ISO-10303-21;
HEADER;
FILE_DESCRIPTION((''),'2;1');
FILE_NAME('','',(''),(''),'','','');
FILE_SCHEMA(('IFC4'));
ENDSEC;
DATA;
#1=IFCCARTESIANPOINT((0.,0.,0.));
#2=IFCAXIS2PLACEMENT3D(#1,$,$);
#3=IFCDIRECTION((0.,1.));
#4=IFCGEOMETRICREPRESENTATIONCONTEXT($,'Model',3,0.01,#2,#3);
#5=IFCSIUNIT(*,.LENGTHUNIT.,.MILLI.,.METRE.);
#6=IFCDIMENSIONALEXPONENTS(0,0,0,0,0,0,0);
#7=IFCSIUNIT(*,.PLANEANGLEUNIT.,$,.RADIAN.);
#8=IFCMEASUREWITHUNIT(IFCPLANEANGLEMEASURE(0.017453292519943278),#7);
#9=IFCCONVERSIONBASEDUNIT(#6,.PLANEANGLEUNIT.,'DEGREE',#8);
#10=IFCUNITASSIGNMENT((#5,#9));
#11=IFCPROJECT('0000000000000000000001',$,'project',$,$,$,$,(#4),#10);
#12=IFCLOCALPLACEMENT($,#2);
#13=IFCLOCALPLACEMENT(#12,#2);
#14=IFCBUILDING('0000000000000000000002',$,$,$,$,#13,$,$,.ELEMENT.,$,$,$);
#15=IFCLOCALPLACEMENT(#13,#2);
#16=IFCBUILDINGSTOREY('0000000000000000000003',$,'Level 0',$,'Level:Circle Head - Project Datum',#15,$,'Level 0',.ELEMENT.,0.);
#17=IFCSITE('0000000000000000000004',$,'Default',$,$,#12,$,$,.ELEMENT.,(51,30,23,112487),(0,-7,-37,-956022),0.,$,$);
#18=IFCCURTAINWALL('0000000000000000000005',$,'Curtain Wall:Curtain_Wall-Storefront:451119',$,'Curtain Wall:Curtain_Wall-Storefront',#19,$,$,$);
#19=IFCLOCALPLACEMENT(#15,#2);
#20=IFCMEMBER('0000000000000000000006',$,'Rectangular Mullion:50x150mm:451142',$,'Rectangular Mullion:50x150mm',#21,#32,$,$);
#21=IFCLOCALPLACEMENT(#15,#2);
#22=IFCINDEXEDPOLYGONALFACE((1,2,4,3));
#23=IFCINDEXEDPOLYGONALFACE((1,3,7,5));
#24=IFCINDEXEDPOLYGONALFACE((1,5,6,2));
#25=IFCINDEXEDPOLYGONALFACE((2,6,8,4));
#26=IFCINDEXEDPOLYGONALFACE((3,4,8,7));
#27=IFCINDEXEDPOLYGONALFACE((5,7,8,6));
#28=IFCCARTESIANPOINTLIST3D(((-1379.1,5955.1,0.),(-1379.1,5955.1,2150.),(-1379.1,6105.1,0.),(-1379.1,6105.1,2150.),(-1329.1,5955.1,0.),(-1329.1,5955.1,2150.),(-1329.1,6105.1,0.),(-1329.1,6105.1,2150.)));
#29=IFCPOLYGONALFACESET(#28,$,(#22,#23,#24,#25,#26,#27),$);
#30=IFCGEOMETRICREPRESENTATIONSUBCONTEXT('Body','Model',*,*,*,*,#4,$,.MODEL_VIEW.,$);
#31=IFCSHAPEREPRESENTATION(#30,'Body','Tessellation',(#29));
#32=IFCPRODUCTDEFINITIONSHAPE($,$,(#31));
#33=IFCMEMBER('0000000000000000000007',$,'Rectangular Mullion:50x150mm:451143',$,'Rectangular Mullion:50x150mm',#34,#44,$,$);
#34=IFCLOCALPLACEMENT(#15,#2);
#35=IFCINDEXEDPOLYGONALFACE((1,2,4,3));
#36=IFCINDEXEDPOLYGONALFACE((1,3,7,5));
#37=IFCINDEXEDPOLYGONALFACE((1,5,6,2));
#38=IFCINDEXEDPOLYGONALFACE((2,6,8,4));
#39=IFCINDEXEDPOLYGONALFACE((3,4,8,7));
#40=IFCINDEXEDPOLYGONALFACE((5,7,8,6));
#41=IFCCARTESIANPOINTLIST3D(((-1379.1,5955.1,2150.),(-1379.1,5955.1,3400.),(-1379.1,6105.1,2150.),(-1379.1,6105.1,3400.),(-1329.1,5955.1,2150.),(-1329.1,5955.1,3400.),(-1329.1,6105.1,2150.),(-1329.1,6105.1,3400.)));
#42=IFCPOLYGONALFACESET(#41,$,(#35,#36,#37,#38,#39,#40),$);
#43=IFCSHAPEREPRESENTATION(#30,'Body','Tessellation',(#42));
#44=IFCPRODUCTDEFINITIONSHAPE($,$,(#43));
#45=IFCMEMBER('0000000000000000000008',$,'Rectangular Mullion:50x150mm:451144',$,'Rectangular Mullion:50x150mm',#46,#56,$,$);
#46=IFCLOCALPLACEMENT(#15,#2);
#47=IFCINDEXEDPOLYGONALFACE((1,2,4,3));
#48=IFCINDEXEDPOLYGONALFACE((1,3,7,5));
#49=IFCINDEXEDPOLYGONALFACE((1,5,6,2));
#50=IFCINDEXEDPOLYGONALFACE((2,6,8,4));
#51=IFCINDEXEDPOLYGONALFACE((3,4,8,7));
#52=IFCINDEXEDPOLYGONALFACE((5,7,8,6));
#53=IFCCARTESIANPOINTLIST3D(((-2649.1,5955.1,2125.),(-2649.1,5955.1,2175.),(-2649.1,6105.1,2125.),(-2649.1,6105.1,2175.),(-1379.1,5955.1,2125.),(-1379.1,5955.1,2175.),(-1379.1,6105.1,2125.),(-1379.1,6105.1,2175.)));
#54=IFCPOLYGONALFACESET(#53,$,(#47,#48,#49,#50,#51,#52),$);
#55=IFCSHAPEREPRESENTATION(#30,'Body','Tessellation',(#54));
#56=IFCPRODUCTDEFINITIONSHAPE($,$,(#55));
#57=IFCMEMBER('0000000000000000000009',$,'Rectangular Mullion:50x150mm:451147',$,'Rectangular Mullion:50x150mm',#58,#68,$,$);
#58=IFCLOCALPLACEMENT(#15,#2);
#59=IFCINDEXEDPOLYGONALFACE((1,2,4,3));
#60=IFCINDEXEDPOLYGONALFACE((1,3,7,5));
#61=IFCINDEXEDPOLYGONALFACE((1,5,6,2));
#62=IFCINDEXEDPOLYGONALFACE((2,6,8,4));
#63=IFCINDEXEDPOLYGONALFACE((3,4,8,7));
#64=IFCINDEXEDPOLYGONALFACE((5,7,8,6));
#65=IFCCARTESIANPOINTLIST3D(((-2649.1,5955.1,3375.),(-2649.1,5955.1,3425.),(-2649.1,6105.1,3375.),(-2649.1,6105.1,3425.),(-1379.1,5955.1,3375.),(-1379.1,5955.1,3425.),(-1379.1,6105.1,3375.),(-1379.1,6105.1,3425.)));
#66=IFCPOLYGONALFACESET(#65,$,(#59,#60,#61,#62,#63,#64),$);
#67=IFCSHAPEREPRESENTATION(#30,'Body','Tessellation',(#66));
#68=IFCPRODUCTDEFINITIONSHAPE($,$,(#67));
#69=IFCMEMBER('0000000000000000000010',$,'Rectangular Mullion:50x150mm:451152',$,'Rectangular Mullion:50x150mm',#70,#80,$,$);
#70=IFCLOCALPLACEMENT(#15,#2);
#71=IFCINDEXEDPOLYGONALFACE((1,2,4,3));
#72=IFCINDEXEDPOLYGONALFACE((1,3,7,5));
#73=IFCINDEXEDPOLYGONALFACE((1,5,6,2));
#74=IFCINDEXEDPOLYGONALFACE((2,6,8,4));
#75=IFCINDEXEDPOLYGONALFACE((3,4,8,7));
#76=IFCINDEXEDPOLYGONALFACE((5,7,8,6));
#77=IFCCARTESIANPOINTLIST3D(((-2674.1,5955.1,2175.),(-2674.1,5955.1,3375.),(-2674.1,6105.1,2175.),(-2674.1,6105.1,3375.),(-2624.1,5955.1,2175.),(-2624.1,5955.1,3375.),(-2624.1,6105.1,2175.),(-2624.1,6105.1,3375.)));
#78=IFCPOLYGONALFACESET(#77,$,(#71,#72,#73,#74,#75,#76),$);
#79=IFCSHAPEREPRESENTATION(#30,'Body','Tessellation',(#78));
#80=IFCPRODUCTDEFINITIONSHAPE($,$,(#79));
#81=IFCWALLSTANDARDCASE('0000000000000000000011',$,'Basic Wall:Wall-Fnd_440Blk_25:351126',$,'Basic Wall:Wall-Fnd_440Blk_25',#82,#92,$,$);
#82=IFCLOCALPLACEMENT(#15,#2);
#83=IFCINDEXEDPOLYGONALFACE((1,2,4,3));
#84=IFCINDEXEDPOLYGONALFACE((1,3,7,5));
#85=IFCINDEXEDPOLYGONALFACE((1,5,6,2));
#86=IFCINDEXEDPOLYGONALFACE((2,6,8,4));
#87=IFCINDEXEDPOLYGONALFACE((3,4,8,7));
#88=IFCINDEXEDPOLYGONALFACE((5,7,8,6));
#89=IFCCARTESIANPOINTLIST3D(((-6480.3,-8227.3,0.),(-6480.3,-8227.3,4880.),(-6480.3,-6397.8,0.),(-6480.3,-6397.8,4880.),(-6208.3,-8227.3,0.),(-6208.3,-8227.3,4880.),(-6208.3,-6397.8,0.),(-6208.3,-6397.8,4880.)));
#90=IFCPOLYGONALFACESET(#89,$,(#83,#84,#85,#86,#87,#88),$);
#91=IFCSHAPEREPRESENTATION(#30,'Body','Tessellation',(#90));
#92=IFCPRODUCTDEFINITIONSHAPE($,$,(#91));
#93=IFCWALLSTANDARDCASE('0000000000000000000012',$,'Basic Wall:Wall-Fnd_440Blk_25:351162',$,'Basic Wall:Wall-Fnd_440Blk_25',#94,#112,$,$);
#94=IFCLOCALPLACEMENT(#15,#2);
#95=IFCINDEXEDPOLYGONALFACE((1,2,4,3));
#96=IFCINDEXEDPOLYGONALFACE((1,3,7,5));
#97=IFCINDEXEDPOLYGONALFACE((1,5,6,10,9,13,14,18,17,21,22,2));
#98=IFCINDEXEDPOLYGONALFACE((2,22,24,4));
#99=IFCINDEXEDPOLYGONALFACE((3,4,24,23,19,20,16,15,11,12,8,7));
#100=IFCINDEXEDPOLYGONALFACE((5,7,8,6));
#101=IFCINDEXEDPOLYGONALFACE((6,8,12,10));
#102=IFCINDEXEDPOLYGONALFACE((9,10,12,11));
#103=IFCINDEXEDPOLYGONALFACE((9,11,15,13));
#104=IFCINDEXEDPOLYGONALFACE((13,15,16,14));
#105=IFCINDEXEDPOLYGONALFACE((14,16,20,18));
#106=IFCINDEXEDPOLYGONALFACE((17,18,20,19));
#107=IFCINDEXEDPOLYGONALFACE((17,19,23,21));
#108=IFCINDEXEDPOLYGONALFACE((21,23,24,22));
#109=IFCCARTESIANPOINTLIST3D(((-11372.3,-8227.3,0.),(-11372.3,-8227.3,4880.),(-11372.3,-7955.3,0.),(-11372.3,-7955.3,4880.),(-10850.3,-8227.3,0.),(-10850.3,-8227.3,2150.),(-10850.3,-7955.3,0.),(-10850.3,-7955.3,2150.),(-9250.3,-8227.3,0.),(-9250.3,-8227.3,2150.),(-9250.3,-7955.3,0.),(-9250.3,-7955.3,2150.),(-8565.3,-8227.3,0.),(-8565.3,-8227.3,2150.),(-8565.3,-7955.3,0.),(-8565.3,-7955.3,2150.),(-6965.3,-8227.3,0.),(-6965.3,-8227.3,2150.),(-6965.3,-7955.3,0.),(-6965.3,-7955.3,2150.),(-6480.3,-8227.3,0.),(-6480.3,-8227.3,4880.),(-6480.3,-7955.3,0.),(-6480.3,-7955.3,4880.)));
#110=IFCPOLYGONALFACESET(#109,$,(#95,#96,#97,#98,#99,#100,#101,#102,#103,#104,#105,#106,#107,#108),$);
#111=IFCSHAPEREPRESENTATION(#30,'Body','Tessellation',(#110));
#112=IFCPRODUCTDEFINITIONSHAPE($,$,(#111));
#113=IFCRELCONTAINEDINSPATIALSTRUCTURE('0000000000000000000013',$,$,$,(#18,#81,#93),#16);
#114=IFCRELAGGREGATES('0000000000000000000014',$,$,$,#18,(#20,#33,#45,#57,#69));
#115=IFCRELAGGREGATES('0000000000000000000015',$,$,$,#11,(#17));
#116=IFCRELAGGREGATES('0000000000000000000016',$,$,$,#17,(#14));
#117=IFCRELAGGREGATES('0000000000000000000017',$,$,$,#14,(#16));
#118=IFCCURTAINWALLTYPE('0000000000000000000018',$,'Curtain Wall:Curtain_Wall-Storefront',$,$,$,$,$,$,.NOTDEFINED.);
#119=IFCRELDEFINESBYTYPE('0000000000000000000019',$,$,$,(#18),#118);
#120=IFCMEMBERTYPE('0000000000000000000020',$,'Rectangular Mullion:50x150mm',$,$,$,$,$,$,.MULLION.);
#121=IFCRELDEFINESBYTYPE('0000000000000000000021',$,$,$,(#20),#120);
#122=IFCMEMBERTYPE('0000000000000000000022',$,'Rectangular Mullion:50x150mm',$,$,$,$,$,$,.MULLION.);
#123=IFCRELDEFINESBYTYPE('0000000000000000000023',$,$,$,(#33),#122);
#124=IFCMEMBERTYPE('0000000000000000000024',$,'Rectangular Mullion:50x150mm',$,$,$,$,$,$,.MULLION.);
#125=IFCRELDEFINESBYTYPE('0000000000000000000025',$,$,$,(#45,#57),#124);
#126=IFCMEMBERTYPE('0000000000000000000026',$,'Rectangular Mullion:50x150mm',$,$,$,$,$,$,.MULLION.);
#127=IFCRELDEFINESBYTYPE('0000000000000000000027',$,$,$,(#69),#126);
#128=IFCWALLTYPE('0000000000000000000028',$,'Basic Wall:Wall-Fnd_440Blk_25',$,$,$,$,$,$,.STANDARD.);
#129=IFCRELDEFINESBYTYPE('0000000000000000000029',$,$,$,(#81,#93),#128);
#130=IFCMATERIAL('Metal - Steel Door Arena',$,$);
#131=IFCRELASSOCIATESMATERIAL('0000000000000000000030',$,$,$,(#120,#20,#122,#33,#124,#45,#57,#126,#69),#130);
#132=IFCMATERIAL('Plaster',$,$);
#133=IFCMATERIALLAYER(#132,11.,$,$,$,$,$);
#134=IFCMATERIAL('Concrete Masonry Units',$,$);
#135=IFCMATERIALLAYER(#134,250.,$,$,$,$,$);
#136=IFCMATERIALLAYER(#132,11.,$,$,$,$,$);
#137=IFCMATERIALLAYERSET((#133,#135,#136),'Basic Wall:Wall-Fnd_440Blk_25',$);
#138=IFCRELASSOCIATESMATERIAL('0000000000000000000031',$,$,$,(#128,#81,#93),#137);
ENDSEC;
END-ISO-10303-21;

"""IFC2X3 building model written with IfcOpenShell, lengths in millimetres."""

from ifc_helpers import new_model, entity, si_unit, converted_unit, direction, frame, frame_2d, origin, origin_2d_with_axis, place, context, subcontext, project, spatial, polyline, rectangle, extrude, clip, bounded_halfspace, source, transform, mapped, material, layer, layer_set, layer_usage, type_object, type_shapes, element, aggregate, save


model = new_model("IFC2X3")

# Units and contexts
model_context = context("Model", 3, precision=0.01, world=origin(), true_north=direction((0.0, 1.0)))
body_context = subcontext(model_context, "Body", "Model", "MODEL_VIEW")
ifc_project = project(units=[si_unit("LENGTHUNIT", "METRE", prefix="MILLI"), converted_unit("PLANEANGLEUNIT", "DEGREE", entity("IfcPlaneAngleMeasure", 0.017453292519943278), si_unit("PLANEANGLEUNIT", "RADIAN"), dimensions=[0, 0, 0, 0, 0, 0, 0])], contexts=[model_context])

# Site, building, storey
site_placement = place(None, origin())
site = spatial("IfcSite", under=ifc_project, at=site_placement, Name="Default", CompositionType="ELEMENT", RefLatitude=(51, 30, 23, 112487), RefLongitude=(0, -7, -37, -956022), RefElevation=0.0)
building_placement = place(site_placement, origin())
building = spatial("IfcBuilding", under=site, at=building_placement, CompositionType="ELEMENT")
storey_placement = place(building_placement, origin())
storey = spatial("IfcBuildingStorey", under=building, at=storey_placement, Name="Level 0", ObjectType="Level:Circle Head - Project Datum", LongName="Level 0", CompositionType="ELEMENT", Elevation=0.0)

# Shared definitions
ifc_material_1 = material(Name="Plaster")

# Curtain wall, members
curtain_wall_type = type_object("IfcCurtainWallType", Name="Curtain Wall:Curtain_Wall-Storefront", PredefinedType="NOTDEFINED")
curtain_wall_placement = place(storey_placement, origin())
curtain_wall = element("IfcCurtainWall", 1, at=curtain_wall_placement, inside=storey, type_object=curtain_wall_type, Name="Curtain Wall:Curtain_Wall-Storefront:451119", ObjectType="Curtain Wall:Curtain_Wall-Storefront")
ifc_material_2 = material(Name="Metal - Steel Door Arena")
member_type_1 = type_object("IfcMemberType", Name="Rectangular Mullion:50x150mm", PredefinedType="MULLION", material=ifc_material_2)
shared_shape_1 = source(origin(), body_context, "Body", "SweptSolid", [
    extrude(rectangle(XDim=50.0, YDim=150.0, at=origin_2d_with_axis()), frame((-25.0, 0.0, -2150.0), z_axis=(0.0, 0.0, 1.0), x_axis=(-1.0, 0.0, 0.0)), (0.0, 0.0, 1.0), 2150.0),
])
type_shapes(member_type_1, [shared_shape_1])
member_1_placement = place(curtain_wall_placement, frame((-1329.1, 6030.1, 2150.0)))
member_1 = element("IfcMember", 2, at=member_1_placement, type_object=member_type_1, material=ifc_material_2, Name="Rectangular Mullion:50x150mm:451142", ObjectType="Rectangular Mullion:50x150mm", context=body_context, shape_type="MappedRepresentation", body=[
    mapped(shared_shape_1, transform((0.0, 0.0, 0.0), scale=1.0)),
])
member_type_2 = type_object("IfcMemberType", Name="Rectangular Mullion:50x150mm", PredefinedType="MULLION", material=ifc_material_2)
shared_shape_2 = source(origin(), body_context, "Body", "SweptSolid", [
    extrude(rectangle(XDim=50.0, YDim=150.0, at=origin_2d_with_axis()), frame((-25.0, 0.0, -1250.0), z_axis=(0.0, 0.0, 1.0), x_axis=(-1.0, 0.0, 0.0)), (0.0, 0.0, 1.0), 1250.0),
])
type_shapes(member_type_2, [shared_shape_2])
member_2_placement = place(curtain_wall_placement, frame((-1329.1, 6030.1, 3400.0)))
member_2 = element("IfcMember", 3, at=member_2_placement, type_object=member_type_2, material=ifc_material_2, Name="Rectangular Mullion:50x150mm:451143", ObjectType="Rectangular Mullion:50x150mm", context=body_context, shape_type="MappedRepresentation", body=[
    mapped(shared_shape_2, transform((0.0, 0.0, 0.0), scale=1.0)),
])
member_type_3 = type_object("IfcMemberType", Name="Rectangular Mullion:50x150mm", PredefinedType="MULLION", material=ifc_material_2)
shared_shape_3 = source(origin(), body_context, "Body", "SweptSolid", [
    extrude(rectangle(XDim=50.0, YDim=150.0, at=origin_2d_with_axis()), frame((0.0, 0.0, -1270.0), z_axis=(0.0, 0.0, 1.0), x_axis=(-1.0, 0.0, 0.0)), (0.0, 0.0, 1.0), 1270.0),
])
type_shapes(member_type_3, [shared_shape_3])
member_3_placement = place(curtain_wall_placement, frame((-2649.1, 6030.1, 2150.0), z_axis=(-1.0, 0.0, 0.0), x_axis=(0.0, 0.0, 1.0)))
member_3 = element("IfcMember", 4, at=member_3_placement, type_object=member_type_3, material=ifc_material_2, Name="Rectangular Mullion:50x150mm:451144", ObjectType="Rectangular Mullion:50x150mm", context=body_context, shape_type="MappedRepresentation", body=[
    mapped(shared_shape_3, transform((0.0, 0.0, 0.0), scale=1.0)),
])
member_4_placement = place(curtain_wall_placement, frame((-2649.1, 6030.1, 3400.0), z_axis=(-1.0, 0.0, 0.0), x_axis=(0.0, 0.0, 1.0)))
member_4 = element("IfcMember", 5, at=member_4_placement, type_object=member_type_3, material=ifc_material_2, Name="Rectangular Mullion:50x150mm:451147", ObjectType="Rectangular Mullion:50x150mm", context=body_context, shape_type="MappedRepresentation", body=[
    mapped(shared_shape_3, transform((0.0, 0.0, 0.0), scale=1.0)),
])
member_type_4 = type_object("IfcMemberType", Name="Rectangular Mullion:50x150mm", PredefinedType="MULLION", material=ifc_material_2)
shared_shape_4 = source(origin(), body_context, "Body", "SweptSolid", [
    extrude(rectangle(XDim=50.0, YDim=150.0, at=origin_2d_with_axis()), frame((0.0, 0.0, -1200.0), z_axis=(0.0, 0.0, 1.0), x_axis=(-1.0, 0.0, 0.0)), (0.0, 0.0, 1.0), 1200.0),
])
type_shapes(member_type_4, [shared_shape_4])
member_5_placement = place(curtain_wall_placement, frame((-2649.1, 6030.1, 2175.0), z_axis=(0.0, 0.0, -1.0), x_axis=(-1.0, 0.0, 0.0)))
member_5 = element("IfcMember", 6, at=member_5_placement, type_object=member_type_4, material=ifc_material_2, Name="Rectangular Mullion:50x150mm:451152", ObjectType="Rectangular Mullion:50x150mm", context=body_context, shape_type="MappedRepresentation", body=[
    mapped(shared_shape_4, transform((0.0, 0.0, 0.0), scale=1.0)),
])

aggregate(curtain_wall, [member_1, member_2, member_3, member_4, member_5])

# Wall
ifc_layer_1 = layer(ifc_material_1, 11.0)
ifc_material_3 = material(Name="Concrete Masonry Units")
ifc_layer_2 = layer(ifc_material_3, 250.0)
ifc_layer_3 = layer(ifc_material_1, 11.0)
ifc_layer_set_1 = layer_set([ifc_layer_1, ifc_layer_2, ifc_layer_3], Name="Basic Wall:Wall-Fnd_440Blk_25")
ifc_layer_usage_1 = layer_usage(ifc_layer_set_1, "AXIS2", "NEGATIVE", 136.0)
wall_type = type_object("IfcWallType", Name="Basic Wall:Wall-Fnd_440Blk_25", PredefinedType="STANDARD", material=ifc_layer_set_1)
wall_1_placement = place(storey_placement, frame((-6344.3, -6397.8, 0.0), z_axis=(0.0, 0.0, 1.0), x_axis=(0.0, -1.0, 0.0)))
element("IfcWallStandardCase", 7, at=wall_1_placement, inside=storey, type_object=wall_type, material=ifc_layer_usage_1, Name="Basic Wall:Wall-Fnd_440Blk_25:351126", ObjectType="Basic Wall:Wall-Fnd_440Blk_25", context=body_context, shape_type="SweptSolid", body=[
    extrude(rectangle(XDim=1829.5, YDim=272.0, at=frame_2d((914.8, 0.0), x_axis=(-1.0, 0.0))), origin(), (0.0, 0.0, 1.0), 4880.0),
])

# Wall, openings
wall_2_placement = place(storey_placement, frame((-6480.3, -8091.3, 0.0), z_axis=(0.0, 0.0, 1.0), x_axis=(-1.0, 0.0, 0.0)))
wall_2 = element("IfcWallStandardCase", 8, at=wall_2_placement, inside=storey, type_object=wall_type, material=ifc_layer_usage_1, Name="Basic Wall:Wall-Fnd_440Blk_25:351162", ObjectType="Basic Wall:Wall-Fnd_440Blk_25", context=body_context, shape_type="Clipping", body=[
    clip(extrude(rectangle(XDim=4892.0, YDim=272.0, at=frame_2d((2446.0, 0.0), x_axis=(-1.0, 0.0))), origin(), (0.0, 0.0, 1.0), 4880.0), bounded_halfspace(frame((0.0, -136.0, 4880.0), z_axis=(0.0, 0.0, -1.0), x_axis=(-1.0, 0.0, 0.0)), True, frame((0.0, -136.0, 4880.0)), polyline([(0.0, 0.0), (1408176.0, 0.0), (1491081.6, 0.0), (1491081.6, 82905.6), (0.0, 82905.6), (0.0, 0.0)]))),
])
opening_1_placement = place(wall_2_placement, frame((2085.0, 136.0, 0.0)))
element("IfcOpeningElement", 9, at=opening_1_placement, cuts=wall_2, ObjectType="Opening", context=body_context, shape_type="SweptSolid", body=[
    extrude(rectangle(XDim=2150.0, YDim=1600.0, at=frame_2d((1075.0, 800.0), x_axis=(1.0, 0.0))), frame((0.0, 0.0, 0.0), z_axis=(0.0, -1.0, 0.0), x_axis=(0.0, 0.0, 1.0)), (0.0, 0.0, 1.0), 272.0),
])
opening_2_placement = place(wall_2_placement, frame((4370.0, 136.0, 0.0)))
element("IfcOpeningElement", 10, at=opening_2_placement, cuts=wall_2, ObjectType="Opening", context=body_context, shape_type="SweptSolid", body=[
    extrude(rectangle(XDim=2150.0, YDim=1600.0, at=frame_2d((1075.0, 800.0), x_axis=(1.0, 0.0))), frame((0.0, 0.0, 0.0), z_axis=(0.0, -1.0, 0.0), x_axis=(0.0, 0.0, 1.0)), (0.0, 0.0, 1.0), 272.0),
])

save(model, "model.ifc")
